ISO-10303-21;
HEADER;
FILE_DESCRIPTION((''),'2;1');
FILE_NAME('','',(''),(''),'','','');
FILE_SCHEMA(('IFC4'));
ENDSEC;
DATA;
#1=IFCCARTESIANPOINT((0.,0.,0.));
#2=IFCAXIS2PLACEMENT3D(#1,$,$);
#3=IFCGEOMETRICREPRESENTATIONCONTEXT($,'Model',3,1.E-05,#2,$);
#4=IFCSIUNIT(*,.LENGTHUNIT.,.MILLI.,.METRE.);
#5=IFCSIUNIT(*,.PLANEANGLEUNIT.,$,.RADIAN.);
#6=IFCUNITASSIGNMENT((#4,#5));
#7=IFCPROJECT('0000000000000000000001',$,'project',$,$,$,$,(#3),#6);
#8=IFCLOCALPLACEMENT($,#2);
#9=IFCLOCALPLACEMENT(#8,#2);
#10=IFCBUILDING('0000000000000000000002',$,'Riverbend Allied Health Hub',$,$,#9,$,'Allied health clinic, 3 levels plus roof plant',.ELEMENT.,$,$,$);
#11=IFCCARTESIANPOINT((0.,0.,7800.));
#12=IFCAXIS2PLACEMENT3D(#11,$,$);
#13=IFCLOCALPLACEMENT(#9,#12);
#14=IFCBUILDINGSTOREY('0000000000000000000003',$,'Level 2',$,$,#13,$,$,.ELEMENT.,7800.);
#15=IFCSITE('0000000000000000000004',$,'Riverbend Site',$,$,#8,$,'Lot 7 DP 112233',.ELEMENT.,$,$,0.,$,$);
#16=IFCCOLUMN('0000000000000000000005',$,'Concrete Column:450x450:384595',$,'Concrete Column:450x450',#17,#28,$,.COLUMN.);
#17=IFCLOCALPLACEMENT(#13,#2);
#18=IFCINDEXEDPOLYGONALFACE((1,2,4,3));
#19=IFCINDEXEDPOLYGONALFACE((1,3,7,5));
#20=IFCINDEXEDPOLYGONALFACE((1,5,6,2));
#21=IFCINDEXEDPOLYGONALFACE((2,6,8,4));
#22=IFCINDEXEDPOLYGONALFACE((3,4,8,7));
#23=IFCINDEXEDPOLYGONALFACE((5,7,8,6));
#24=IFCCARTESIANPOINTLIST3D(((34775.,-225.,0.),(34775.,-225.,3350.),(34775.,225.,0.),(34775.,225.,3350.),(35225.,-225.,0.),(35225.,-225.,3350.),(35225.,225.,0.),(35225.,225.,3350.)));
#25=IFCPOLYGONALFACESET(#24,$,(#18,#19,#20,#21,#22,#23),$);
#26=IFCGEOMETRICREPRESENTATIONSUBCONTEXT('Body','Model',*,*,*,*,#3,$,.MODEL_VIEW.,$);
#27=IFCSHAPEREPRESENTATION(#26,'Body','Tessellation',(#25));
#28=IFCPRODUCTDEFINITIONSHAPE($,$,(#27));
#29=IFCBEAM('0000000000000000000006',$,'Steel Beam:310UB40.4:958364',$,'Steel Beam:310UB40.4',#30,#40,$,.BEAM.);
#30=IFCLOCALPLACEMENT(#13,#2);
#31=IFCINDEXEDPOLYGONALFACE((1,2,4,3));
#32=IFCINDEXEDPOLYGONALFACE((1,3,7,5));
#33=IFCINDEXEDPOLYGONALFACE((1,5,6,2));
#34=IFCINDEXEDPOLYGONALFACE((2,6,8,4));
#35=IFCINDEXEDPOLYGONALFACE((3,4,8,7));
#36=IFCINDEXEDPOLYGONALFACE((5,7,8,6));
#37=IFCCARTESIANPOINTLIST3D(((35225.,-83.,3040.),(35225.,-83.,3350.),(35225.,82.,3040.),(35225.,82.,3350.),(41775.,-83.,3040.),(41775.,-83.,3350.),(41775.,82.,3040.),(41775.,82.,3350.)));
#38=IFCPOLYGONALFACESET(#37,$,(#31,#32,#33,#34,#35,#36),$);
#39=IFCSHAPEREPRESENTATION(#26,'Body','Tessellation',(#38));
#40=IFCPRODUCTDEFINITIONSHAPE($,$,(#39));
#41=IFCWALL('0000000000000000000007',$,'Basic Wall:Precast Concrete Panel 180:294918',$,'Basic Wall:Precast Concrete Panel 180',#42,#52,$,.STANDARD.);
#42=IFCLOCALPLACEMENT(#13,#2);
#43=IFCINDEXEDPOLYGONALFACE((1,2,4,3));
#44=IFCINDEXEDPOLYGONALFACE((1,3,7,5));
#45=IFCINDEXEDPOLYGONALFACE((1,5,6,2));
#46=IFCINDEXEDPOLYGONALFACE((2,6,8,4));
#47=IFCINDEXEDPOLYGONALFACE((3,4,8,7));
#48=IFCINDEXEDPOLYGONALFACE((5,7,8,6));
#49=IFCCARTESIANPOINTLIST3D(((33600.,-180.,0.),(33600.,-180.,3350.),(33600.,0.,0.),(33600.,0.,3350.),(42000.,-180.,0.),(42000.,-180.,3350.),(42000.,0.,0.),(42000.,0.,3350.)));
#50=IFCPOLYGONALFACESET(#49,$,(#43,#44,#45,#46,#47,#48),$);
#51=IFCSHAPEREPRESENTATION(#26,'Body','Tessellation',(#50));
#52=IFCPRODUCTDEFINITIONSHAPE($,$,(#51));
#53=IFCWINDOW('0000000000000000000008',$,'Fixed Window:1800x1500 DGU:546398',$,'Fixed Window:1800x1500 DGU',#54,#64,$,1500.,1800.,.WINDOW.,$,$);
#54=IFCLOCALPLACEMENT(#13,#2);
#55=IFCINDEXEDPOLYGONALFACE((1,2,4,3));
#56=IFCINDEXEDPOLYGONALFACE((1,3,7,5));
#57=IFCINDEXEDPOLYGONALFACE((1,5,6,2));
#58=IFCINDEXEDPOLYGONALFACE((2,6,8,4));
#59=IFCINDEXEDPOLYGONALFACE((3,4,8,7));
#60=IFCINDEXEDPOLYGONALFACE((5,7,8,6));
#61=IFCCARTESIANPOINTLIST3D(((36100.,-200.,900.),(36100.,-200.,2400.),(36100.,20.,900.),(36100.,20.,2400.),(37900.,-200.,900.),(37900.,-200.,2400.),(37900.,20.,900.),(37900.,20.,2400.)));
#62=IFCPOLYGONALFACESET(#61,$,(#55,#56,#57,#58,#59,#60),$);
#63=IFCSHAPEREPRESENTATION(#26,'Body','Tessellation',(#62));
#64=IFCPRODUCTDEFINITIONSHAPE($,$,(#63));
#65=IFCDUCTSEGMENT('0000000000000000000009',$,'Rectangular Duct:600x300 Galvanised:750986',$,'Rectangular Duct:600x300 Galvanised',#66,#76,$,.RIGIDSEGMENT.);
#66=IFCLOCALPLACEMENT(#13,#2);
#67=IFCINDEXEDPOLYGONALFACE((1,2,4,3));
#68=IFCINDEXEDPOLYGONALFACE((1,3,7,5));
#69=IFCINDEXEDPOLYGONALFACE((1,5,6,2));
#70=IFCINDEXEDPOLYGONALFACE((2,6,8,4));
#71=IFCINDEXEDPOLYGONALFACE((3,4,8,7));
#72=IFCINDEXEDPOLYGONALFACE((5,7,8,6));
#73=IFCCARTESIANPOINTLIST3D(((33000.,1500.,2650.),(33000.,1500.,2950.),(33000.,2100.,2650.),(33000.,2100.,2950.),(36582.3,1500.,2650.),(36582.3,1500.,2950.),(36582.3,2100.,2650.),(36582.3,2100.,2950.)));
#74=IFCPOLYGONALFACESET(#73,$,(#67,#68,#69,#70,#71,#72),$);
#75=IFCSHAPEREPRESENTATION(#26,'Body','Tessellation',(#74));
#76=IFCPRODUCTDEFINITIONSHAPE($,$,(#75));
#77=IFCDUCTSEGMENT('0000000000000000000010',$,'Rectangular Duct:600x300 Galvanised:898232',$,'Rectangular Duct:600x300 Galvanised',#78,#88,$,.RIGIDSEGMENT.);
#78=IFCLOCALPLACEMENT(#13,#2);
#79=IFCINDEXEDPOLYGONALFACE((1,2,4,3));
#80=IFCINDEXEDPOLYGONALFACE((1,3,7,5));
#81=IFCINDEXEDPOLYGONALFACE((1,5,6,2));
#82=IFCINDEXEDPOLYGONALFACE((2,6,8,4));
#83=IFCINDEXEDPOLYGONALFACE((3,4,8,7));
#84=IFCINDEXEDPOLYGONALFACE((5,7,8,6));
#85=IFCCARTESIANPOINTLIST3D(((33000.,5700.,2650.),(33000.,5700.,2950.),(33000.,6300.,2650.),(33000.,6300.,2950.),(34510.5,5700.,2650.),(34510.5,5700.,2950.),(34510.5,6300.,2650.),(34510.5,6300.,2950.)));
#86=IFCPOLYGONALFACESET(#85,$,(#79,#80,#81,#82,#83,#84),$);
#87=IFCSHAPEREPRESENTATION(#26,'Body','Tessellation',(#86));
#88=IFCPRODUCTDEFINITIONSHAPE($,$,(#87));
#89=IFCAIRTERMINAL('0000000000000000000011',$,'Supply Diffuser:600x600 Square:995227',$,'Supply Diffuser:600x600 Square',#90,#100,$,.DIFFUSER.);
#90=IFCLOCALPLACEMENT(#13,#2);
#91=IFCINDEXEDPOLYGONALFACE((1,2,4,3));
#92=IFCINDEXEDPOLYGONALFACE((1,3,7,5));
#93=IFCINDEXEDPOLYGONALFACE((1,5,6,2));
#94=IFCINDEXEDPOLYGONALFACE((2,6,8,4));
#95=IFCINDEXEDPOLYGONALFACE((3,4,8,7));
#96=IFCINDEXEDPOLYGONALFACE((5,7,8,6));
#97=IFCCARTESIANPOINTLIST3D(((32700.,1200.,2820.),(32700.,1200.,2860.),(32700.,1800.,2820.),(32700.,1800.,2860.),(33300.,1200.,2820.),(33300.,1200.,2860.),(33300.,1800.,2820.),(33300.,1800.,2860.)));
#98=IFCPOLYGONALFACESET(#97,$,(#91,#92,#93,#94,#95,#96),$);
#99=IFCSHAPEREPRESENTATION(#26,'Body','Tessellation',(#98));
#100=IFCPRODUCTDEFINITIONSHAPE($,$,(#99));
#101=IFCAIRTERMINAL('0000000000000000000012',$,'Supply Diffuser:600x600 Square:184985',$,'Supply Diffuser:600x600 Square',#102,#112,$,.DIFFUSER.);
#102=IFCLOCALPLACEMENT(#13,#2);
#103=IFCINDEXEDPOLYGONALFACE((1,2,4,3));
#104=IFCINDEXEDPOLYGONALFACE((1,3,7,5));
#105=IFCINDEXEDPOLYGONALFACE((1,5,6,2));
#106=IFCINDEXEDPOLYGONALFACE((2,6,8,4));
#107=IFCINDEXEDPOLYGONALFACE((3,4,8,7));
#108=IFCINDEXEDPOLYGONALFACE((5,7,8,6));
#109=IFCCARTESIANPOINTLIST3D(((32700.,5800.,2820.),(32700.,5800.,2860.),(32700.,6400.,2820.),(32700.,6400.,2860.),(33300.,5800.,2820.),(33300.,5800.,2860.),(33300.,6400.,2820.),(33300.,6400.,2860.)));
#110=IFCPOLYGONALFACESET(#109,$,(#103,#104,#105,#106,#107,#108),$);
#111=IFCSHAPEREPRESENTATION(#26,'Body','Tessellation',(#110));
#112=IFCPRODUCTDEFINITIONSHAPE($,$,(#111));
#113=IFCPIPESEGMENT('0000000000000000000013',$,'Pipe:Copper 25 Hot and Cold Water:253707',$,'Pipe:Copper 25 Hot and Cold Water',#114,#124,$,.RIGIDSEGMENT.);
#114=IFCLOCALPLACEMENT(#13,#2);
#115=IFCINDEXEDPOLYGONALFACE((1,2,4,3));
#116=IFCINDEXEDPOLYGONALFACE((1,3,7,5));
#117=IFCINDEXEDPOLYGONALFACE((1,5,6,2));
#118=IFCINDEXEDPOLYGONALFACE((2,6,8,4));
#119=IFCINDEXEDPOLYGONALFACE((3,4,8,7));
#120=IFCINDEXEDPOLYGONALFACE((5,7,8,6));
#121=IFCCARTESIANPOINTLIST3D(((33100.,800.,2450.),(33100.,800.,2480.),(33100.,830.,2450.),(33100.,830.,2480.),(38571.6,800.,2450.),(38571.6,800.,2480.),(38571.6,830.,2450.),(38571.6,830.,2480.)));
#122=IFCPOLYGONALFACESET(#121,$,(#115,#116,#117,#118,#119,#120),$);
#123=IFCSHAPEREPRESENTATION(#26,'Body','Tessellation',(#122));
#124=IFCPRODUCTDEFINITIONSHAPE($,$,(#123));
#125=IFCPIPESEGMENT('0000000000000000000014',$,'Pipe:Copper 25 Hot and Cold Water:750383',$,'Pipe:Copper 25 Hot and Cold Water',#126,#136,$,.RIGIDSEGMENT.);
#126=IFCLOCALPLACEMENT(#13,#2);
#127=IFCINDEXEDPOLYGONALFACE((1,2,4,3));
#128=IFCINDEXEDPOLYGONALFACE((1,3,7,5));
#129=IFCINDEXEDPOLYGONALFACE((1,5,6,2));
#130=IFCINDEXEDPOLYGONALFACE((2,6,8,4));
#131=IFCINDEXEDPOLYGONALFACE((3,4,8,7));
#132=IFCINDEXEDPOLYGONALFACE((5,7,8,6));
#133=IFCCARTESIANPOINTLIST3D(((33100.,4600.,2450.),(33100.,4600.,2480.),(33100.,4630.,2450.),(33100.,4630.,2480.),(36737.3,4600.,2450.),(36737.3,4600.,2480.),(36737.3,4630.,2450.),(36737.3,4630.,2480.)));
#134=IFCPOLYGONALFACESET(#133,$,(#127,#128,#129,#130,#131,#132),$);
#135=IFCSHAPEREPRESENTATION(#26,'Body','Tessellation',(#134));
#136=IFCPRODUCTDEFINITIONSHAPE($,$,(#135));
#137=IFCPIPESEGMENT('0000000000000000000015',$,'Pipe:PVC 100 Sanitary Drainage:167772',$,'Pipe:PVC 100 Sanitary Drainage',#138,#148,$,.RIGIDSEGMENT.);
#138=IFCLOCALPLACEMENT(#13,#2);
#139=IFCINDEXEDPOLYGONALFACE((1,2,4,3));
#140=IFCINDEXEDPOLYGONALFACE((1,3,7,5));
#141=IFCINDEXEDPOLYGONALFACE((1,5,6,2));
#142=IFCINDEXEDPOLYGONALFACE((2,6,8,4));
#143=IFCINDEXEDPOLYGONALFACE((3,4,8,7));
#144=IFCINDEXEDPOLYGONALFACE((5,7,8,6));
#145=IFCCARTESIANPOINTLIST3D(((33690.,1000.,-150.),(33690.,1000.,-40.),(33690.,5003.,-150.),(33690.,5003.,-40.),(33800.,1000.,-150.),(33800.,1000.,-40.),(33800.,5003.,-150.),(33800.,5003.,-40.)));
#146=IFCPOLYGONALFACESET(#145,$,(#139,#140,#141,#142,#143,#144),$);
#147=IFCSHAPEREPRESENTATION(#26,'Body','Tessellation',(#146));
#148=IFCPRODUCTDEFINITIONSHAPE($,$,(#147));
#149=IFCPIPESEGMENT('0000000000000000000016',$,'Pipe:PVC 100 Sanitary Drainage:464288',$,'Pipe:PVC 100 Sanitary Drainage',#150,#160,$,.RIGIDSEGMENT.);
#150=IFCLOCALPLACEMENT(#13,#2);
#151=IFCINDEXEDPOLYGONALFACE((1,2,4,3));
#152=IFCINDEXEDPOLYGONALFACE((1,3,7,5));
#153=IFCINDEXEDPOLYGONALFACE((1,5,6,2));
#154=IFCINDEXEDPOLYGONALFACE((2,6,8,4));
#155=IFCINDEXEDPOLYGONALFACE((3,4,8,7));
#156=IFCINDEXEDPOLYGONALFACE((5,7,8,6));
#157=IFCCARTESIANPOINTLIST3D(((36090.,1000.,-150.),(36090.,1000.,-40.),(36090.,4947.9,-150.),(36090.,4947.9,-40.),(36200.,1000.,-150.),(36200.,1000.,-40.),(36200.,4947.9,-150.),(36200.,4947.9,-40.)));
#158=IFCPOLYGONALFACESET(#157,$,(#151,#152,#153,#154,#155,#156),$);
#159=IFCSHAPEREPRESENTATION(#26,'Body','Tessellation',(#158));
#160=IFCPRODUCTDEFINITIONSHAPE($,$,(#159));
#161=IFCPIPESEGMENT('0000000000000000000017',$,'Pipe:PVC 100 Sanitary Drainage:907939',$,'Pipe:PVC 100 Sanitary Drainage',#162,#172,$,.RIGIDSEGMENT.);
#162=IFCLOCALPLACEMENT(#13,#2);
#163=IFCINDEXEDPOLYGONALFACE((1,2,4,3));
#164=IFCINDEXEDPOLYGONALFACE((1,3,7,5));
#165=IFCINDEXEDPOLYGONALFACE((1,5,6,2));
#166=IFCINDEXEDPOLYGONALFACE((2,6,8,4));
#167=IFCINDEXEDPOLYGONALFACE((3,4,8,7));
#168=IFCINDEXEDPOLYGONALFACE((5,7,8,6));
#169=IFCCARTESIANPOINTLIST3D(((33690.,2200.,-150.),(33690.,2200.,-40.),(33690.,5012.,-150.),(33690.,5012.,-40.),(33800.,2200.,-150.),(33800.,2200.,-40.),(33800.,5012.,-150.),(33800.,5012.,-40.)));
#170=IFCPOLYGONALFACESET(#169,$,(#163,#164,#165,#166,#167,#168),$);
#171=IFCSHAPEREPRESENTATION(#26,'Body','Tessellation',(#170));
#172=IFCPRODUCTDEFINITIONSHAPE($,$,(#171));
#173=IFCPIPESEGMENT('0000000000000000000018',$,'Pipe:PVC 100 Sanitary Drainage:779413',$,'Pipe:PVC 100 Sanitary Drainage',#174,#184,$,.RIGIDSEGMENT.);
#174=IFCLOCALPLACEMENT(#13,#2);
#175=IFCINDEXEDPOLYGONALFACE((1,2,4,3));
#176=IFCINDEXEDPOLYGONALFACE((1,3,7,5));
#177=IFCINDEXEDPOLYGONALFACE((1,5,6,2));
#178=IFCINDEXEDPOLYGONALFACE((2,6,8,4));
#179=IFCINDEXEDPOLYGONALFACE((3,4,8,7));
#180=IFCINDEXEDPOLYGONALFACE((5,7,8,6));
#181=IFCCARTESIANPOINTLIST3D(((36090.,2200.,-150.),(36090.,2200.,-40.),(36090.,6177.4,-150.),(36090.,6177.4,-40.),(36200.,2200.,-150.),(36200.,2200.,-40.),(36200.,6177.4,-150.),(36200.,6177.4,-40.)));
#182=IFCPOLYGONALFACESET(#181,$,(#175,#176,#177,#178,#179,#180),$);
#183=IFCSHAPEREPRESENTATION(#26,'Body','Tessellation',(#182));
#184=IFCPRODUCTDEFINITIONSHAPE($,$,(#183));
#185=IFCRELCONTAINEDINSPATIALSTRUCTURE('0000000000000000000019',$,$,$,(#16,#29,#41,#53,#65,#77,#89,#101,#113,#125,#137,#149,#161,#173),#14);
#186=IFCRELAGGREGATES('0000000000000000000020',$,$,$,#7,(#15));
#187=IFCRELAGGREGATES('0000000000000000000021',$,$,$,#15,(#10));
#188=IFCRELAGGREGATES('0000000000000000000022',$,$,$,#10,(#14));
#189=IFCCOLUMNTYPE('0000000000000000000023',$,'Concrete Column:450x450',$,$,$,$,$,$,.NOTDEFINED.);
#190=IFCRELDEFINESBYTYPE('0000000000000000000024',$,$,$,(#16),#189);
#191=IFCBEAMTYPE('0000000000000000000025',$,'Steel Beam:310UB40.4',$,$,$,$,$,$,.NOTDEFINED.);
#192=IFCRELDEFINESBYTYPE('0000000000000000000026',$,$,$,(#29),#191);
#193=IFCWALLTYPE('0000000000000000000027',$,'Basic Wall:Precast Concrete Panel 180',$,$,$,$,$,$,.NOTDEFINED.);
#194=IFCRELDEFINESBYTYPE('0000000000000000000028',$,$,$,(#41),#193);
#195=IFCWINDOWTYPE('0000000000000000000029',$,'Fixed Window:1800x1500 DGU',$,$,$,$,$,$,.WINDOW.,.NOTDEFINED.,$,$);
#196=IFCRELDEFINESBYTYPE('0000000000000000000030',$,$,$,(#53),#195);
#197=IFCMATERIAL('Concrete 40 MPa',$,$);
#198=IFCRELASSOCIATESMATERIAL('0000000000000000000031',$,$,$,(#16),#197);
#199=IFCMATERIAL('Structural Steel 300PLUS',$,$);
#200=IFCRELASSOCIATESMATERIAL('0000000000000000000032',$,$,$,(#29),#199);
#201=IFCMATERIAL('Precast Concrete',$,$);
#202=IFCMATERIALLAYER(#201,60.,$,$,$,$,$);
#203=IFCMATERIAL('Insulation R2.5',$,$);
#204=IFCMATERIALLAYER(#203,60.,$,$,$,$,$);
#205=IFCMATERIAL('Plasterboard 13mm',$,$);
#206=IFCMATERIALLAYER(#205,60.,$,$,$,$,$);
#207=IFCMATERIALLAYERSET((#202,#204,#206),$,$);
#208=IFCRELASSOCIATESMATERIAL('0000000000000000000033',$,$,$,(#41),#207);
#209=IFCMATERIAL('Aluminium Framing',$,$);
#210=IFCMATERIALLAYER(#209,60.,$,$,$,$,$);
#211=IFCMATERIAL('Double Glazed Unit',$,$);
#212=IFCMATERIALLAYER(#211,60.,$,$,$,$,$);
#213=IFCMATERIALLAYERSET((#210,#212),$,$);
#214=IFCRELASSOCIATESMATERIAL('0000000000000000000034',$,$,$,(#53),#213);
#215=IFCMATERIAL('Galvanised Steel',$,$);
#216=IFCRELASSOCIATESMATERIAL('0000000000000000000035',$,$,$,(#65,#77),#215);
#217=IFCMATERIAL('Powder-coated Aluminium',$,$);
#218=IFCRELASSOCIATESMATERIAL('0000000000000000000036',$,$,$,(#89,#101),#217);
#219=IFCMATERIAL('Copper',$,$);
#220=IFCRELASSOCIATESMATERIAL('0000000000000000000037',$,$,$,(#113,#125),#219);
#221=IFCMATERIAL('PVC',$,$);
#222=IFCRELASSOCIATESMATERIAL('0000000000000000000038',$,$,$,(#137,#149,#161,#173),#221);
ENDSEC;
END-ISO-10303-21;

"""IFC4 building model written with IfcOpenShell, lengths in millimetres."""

from ifc_helpers import new_model, si_unit, frame, frame_2d, origin, place, context, subcontext, project, spatial, rectangle, extrude, material, layer, layer_set, layer_usage, type_object, element, save


model = new_model("IFC4")

# Units and contexts
model_context = context("Model", 3, precision=1e-05, world=origin())
body_context = subcontext(model_context, "Body", "Model", "MODEL_VIEW")
ifc_project = project(units=[si_unit("LENGTHUNIT", "METRE", prefix="MILLI"), si_unit("PLANEANGLEUNIT", "RADIAN")], contexts=[model_context])

# Site, building, storey
site_placement = place(None, origin())
site = spatial("IfcSite", under=ifc_project, at=site_placement, Name="Riverbend Site", LongName="Lot 7 DP 112233", CompositionType="ELEMENT", RefElevation=0.0)
building_placement = place(site_placement, origin())
building = spatial("IfcBuilding", under=site, at=building_placement, Name="Riverbend Allied Health Hub", LongName="Allied health clinic, 3 levels plus roof plant", CompositionType="ELEMENT")
storey_placement = place(building_placement, frame((0.0, 0.0, 7800.0)))
storey = spatial("IfcBuildingStorey", under=building, at=storey_placement, Name="Level 2", CompositionType="ELEMENT", Elevation=7800.0)

# Column
ifc_material_1 = material(Name="Concrete 40 MPa")
column_type = type_object("IfcColumnType", Name="Concrete Column:450x450", PredefinedType="NOTDEFINED")
column_placement = place(storey_placement, frame((34775.0, -225.0, 0.0)))
element("IfcColumn", 1, at=column_placement, inside=storey, type_object=column_type, material=ifc_material_1, Name="Concrete Column:450x450:384595", ObjectType="Concrete Column:450x450", PredefinedType="COLUMN", context=body_context, shape_type="SweptSolid", body=[
    extrude(rectangle(XDim=450.0, YDim=450.0, at=frame_2d((225.0, 225.0))), origin(), (0.0, 0.0, 1.0), 3350.0),
])

# Beam
ifc_material_2 = material(Name="Structural Steel 300PLUS")
beam_type = type_object("IfcBeamType", Name="Steel Beam:310UB40.4", PredefinedType="NOTDEFINED")
beam_placement = place(storey_placement, frame((35225.0, -83.0, 3040.0)))
element("IfcBeam", 2, at=beam_placement, inside=storey, type_object=beam_type, material=ifc_material_2, Name="Steel Beam:310UB40.4:958364", ObjectType="Steel Beam:310UB40.4", PredefinedType="BEAM", context=body_context, shape_type="SweptSolid", body=[
    extrude(rectangle(XDim=6550.0, YDim=165.0, at=frame_2d((3275.0, 82.5))), origin(), (0.0, 0.0, 1.0), 310.0),
])

# Wall
ifc_material_3 = material(Name="Precast Concrete")
ifc_layer_1 = layer(ifc_material_3, 60.0)
ifc_material_4 = material(Name="Insulation R2.5")
ifc_layer_2 = layer(ifc_material_4, 60.0)
ifc_material_5 = material(Name="Plasterboard 13mm")
ifc_layer_3 = layer(ifc_material_5, 60.0)
ifc_layer_set_1 = layer_set([ifc_layer_1, ifc_layer_2, ifc_layer_3])
ifc_layer_usage_1 = layer_usage(ifc_layer_set_1, "AXIS2", "POSITIVE", 0.0)
wall_type = type_object("IfcWallType", Name="Basic Wall:Precast Concrete Panel 180", PredefinedType="NOTDEFINED")
wall_placement = place(storey_placement, frame((33600.0, -180.0, 0.0)))
element("IfcWall", 3, at=wall_placement, inside=storey, type_object=wall_type, material=ifc_layer_usage_1, Name="Basic Wall:Precast Concrete Panel 180:294918", ObjectType="Basic Wall:Precast Concrete Panel 180", PredefinedType="STANDARD", context=body_context, shape_type="SweptSolid", body=[
    extrude(rectangle(XDim=8400.0, YDim=180.0, at=frame_2d((4200.0, 90.0))), origin(), (0.0, 0.0, 1.0), 3350.0),
])

# Window
ifc_material_6 = material(Name="Aluminium Framing")
ifc_layer_4 = layer(ifc_material_6, 60.0)
ifc_material_7 = material(Name="Double Glazed Unit")
ifc_layer_5 = layer(ifc_material_7, 60.0)
ifc_layer_set_2 = layer_set([ifc_layer_4, ifc_layer_5])
ifc_layer_usage_2 = layer_usage(ifc_layer_set_2, "AXIS2", "POSITIVE", 0.0)
window_type = type_object("IfcWindowType", Name="Fixed Window:1800x1500 DGU", PartitioningType="NOTDEFINED", PredefinedType="WINDOW")
window_placement = place(storey_placement, frame((36100.0, -200.0, 900.0)))
element("IfcWindow", 4, at=window_placement, inside=storey, type_object=window_type, material=ifc_layer_usage_2, Name="Fixed Window:1800x1500 DGU:546398", ObjectType="Fixed Window:1800x1500 DGU", OverallHeight=1500.0, OverallWidth=1800.0, PredefinedType="WINDOW", context=body_context, shape_type="SweptSolid", body=[
    extrude(rectangle(XDim=1800.0, YDim=220.0, at=frame_2d((900.0, 110.0))), origin(), (0.0, 0.0, 1.0), 1500.0),
])

# Duct segments
ifc_material_8 = material(Name="Galvanised Steel")
duct_segment_1_placement = place(storey_placement, frame((33000.0, 1500.0, 2650.0)))
element("IfcDuctSegment", 5, at=duct_segment_1_placement, inside=storey, material=ifc_material_8, Name="Rectangular Duct:600x300 Galvanised:750986", ObjectType="Rectangular Duct:600x300 Galvanised", PredefinedType="RIGIDSEGMENT", context=body_context, shape_type="SweptSolid", body=[
    extrude(rectangle(XDim=3582.3, YDim=600.0, at=frame_2d((1791.2, 300.0))), origin(), (0.0, 0.0, 1.0), 300.0),
])
duct_segment_2_placement = place(storey_placement, frame((33000.0, 5700.0, 2650.0)))
element("IfcDuctSegment", 6, at=duct_segment_2_placement, inside=storey, material=ifc_material_8, Name="Rectangular Duct:600x300 Galvanised:898232", ObjectType="Rectangular Duct:600x300 Galvanised", PredefinedType="RIGIDSEGMENT", context=body_context, shape_type="SweptSolid", body=[
    extrude(rectangle(XDim=1510.5, YDim=600.0, at=frame_2d((755.3, 300.0))), origin(), (0.0, 0.0, 1.0), 300.0),
])

# Air terminals
ifc_material_9 = material(Name="Powder-coated Aluminium")
for number, where, name in (
    (7, (32700.0, 1200.0, 2820.0), "Supply Diffuser:600x600 Square:995227"),
    (8, (32700.0, 5800.0, 2820.0), "Supply Diffuser:600x600 Square:184985"),
):
    element("IfcAirTerminal", number, at=place(storey_placement, frame(where)), inside=storey, material=ifc_material_9, Name=name, ObjectType="Supply Diffuser:600x600 Square", PredefinedType="DIFFUSER", context=body_context, shape_type="SweptSolid", body=[
        extrude(rectangle(XDim=600.0, YDim=600.0, at=frame_2d((300.0, 300.0))), origin(), (0.0, 0.0, 1.0), 40.0),
    ])

# Pipe segments
ifc_material_10 = material(Name="Copper")
pipe_segment_1_placement = place(storey_placement, frame((33100.0, 800.0, 2450.0)))
element("IfcPipeSegment", 9, at=pipe_segment_1_placement, inside=storey, material=ifc_material_10, Name="Pipe:Copper 25 Hot and Cold Water:253707", ObjectType="Pipe:Copper 25 Hot and Cold Water", PredefinedType="RIGIDSEGMENT", context=body_context, shape_type="SweptSolid", body=[
    extrude(rectangle(XDim=5471.6, YDim=30.0, at=frame_2d((2735.8, 15.0))), origin(), (0.0, 0.0, 1.0), 30.0),
])
pipe_segment_2_placement = place(storey_placement, frame((33100.0, 4600.0, 2450.0)))
element("IfcPipeSegment", 10, at=pipe_segment_2_placement, inside=storey, material=ifc_material_10, Name="Pipe:Copper 25 Hot and Cold Water:750383", ObjectType="Pipe:Copper 25 Hot and Cold Water", PredefinedType="RIGIDSEGMENT", context=body_context, shape_type="SweptSolid", body=[
    extrude(rectangle(XDim=3637.3, YDim=30.0, at=frame_2d((1818.7, 15.0))), origin(), (0.0, 0.0, 1.0), 30.0),
])
ifc_material_11 = material(Name="PVC")
pipe_segment_3_placement = place(storey_placement, frame((33800.0, 1000.0, -150.0), z_axis=(0.0, 0.0, 1.0), x_axis=(0.0, 1.0, 0.0)))
element("IfcPipeSegment", 11, at=pipe_segment_3_placement, inside=storey, material=ifc_material_11, Name="Pipe:PVC 100 Sanitary Drainage:167772", ObjectType="Pipe:PVC 100 Sanitary Drainage", PredefinedType="RIGIDSEGMENT", context=body_context, shape_type="SweptSolid", body=[
    extrude(rectangle(XDim=4003.0, YDim=110.0, at=frame_2d((2001.5, 55.0))), origin(), (0.0, 0.0, 1.0), 110.0),
])
pipe_segment_4_placement = place(storey_placement, frame((36200.0, 1000.0, -150.0), z_axis=(0.0, 0.0, 1.0), x_axis=(0.0, 1.0, 0.0)))
element("IfcPipeSegment", 12, at=pipe_segment_4_placement, inside=storey, material=ifc_material_11, Name="Pipe:PVC 100 Sanitary Drainage:464288", ObjectType="Pipe:PVC 100 Sanitary Drainage", PredefinedType="RIGIDSEGMENT", context=body_context, shape_type="SweptSolid", body=[
    extrude(rectangle(XDim=3947.9, YDim=110.0, at=frame_2d((1974.0, 55.0))), origin(), (0.0, 0.0, 1.0), 110.0),
])
pipe_segment_5_placement = place(storey_placement, frame((33800.0, 2200.0, -150.0), z_axis=(0.0, 0.0, 1.0), x_axis=(0.0, 1.0, 0.0)))
element("IfcPipeSegment", 13, at=pipe_segment_5_placement, inside=storey, material=ifc_material_11, Name="Pipe:PVC 100 Sanitary Drainage:907939", ObjectType="Pipe:PVC 100 Sanitary Drainage", PredefinedType="RIGIDSEGMENT", context=body_context, shape_type="SweptSolid", body=[
    extrude(rectangle(XDim=2812.0, YDim=110.0, at=frame_2d((1406.0, 55.0))), origin(), (0.0, 0.0, 1.0), 110.0),
])
pipe_segment_6_placement = place(storey_placement, frame((36200.0, 2200.0, -150.0), z_axis=(0.0, 0.0, 1.0), x_axis=(0.0, 1.0, 0.0)))
element("IfcPipeSegment", 14, at=pipe_segment_6_placement, inside=storey, material=ifc_material_11, Name="Pipe:PVC 100 Sanitary Drainage:779413", ObjectType="Pipe:PVC 100 Sanitary Drainage", PredefinedType="RIGIDSEGMENT", context=body_context, shape_type="SweptSolid", body=[
    extrude(rectangle(XDim=3977.4, YDim=110.0, at=frame_2d((1988.7, 55.0))), origin(), (0.0, 0.0, 1.0), 110.0),
])

save(model, "model.ifc")
